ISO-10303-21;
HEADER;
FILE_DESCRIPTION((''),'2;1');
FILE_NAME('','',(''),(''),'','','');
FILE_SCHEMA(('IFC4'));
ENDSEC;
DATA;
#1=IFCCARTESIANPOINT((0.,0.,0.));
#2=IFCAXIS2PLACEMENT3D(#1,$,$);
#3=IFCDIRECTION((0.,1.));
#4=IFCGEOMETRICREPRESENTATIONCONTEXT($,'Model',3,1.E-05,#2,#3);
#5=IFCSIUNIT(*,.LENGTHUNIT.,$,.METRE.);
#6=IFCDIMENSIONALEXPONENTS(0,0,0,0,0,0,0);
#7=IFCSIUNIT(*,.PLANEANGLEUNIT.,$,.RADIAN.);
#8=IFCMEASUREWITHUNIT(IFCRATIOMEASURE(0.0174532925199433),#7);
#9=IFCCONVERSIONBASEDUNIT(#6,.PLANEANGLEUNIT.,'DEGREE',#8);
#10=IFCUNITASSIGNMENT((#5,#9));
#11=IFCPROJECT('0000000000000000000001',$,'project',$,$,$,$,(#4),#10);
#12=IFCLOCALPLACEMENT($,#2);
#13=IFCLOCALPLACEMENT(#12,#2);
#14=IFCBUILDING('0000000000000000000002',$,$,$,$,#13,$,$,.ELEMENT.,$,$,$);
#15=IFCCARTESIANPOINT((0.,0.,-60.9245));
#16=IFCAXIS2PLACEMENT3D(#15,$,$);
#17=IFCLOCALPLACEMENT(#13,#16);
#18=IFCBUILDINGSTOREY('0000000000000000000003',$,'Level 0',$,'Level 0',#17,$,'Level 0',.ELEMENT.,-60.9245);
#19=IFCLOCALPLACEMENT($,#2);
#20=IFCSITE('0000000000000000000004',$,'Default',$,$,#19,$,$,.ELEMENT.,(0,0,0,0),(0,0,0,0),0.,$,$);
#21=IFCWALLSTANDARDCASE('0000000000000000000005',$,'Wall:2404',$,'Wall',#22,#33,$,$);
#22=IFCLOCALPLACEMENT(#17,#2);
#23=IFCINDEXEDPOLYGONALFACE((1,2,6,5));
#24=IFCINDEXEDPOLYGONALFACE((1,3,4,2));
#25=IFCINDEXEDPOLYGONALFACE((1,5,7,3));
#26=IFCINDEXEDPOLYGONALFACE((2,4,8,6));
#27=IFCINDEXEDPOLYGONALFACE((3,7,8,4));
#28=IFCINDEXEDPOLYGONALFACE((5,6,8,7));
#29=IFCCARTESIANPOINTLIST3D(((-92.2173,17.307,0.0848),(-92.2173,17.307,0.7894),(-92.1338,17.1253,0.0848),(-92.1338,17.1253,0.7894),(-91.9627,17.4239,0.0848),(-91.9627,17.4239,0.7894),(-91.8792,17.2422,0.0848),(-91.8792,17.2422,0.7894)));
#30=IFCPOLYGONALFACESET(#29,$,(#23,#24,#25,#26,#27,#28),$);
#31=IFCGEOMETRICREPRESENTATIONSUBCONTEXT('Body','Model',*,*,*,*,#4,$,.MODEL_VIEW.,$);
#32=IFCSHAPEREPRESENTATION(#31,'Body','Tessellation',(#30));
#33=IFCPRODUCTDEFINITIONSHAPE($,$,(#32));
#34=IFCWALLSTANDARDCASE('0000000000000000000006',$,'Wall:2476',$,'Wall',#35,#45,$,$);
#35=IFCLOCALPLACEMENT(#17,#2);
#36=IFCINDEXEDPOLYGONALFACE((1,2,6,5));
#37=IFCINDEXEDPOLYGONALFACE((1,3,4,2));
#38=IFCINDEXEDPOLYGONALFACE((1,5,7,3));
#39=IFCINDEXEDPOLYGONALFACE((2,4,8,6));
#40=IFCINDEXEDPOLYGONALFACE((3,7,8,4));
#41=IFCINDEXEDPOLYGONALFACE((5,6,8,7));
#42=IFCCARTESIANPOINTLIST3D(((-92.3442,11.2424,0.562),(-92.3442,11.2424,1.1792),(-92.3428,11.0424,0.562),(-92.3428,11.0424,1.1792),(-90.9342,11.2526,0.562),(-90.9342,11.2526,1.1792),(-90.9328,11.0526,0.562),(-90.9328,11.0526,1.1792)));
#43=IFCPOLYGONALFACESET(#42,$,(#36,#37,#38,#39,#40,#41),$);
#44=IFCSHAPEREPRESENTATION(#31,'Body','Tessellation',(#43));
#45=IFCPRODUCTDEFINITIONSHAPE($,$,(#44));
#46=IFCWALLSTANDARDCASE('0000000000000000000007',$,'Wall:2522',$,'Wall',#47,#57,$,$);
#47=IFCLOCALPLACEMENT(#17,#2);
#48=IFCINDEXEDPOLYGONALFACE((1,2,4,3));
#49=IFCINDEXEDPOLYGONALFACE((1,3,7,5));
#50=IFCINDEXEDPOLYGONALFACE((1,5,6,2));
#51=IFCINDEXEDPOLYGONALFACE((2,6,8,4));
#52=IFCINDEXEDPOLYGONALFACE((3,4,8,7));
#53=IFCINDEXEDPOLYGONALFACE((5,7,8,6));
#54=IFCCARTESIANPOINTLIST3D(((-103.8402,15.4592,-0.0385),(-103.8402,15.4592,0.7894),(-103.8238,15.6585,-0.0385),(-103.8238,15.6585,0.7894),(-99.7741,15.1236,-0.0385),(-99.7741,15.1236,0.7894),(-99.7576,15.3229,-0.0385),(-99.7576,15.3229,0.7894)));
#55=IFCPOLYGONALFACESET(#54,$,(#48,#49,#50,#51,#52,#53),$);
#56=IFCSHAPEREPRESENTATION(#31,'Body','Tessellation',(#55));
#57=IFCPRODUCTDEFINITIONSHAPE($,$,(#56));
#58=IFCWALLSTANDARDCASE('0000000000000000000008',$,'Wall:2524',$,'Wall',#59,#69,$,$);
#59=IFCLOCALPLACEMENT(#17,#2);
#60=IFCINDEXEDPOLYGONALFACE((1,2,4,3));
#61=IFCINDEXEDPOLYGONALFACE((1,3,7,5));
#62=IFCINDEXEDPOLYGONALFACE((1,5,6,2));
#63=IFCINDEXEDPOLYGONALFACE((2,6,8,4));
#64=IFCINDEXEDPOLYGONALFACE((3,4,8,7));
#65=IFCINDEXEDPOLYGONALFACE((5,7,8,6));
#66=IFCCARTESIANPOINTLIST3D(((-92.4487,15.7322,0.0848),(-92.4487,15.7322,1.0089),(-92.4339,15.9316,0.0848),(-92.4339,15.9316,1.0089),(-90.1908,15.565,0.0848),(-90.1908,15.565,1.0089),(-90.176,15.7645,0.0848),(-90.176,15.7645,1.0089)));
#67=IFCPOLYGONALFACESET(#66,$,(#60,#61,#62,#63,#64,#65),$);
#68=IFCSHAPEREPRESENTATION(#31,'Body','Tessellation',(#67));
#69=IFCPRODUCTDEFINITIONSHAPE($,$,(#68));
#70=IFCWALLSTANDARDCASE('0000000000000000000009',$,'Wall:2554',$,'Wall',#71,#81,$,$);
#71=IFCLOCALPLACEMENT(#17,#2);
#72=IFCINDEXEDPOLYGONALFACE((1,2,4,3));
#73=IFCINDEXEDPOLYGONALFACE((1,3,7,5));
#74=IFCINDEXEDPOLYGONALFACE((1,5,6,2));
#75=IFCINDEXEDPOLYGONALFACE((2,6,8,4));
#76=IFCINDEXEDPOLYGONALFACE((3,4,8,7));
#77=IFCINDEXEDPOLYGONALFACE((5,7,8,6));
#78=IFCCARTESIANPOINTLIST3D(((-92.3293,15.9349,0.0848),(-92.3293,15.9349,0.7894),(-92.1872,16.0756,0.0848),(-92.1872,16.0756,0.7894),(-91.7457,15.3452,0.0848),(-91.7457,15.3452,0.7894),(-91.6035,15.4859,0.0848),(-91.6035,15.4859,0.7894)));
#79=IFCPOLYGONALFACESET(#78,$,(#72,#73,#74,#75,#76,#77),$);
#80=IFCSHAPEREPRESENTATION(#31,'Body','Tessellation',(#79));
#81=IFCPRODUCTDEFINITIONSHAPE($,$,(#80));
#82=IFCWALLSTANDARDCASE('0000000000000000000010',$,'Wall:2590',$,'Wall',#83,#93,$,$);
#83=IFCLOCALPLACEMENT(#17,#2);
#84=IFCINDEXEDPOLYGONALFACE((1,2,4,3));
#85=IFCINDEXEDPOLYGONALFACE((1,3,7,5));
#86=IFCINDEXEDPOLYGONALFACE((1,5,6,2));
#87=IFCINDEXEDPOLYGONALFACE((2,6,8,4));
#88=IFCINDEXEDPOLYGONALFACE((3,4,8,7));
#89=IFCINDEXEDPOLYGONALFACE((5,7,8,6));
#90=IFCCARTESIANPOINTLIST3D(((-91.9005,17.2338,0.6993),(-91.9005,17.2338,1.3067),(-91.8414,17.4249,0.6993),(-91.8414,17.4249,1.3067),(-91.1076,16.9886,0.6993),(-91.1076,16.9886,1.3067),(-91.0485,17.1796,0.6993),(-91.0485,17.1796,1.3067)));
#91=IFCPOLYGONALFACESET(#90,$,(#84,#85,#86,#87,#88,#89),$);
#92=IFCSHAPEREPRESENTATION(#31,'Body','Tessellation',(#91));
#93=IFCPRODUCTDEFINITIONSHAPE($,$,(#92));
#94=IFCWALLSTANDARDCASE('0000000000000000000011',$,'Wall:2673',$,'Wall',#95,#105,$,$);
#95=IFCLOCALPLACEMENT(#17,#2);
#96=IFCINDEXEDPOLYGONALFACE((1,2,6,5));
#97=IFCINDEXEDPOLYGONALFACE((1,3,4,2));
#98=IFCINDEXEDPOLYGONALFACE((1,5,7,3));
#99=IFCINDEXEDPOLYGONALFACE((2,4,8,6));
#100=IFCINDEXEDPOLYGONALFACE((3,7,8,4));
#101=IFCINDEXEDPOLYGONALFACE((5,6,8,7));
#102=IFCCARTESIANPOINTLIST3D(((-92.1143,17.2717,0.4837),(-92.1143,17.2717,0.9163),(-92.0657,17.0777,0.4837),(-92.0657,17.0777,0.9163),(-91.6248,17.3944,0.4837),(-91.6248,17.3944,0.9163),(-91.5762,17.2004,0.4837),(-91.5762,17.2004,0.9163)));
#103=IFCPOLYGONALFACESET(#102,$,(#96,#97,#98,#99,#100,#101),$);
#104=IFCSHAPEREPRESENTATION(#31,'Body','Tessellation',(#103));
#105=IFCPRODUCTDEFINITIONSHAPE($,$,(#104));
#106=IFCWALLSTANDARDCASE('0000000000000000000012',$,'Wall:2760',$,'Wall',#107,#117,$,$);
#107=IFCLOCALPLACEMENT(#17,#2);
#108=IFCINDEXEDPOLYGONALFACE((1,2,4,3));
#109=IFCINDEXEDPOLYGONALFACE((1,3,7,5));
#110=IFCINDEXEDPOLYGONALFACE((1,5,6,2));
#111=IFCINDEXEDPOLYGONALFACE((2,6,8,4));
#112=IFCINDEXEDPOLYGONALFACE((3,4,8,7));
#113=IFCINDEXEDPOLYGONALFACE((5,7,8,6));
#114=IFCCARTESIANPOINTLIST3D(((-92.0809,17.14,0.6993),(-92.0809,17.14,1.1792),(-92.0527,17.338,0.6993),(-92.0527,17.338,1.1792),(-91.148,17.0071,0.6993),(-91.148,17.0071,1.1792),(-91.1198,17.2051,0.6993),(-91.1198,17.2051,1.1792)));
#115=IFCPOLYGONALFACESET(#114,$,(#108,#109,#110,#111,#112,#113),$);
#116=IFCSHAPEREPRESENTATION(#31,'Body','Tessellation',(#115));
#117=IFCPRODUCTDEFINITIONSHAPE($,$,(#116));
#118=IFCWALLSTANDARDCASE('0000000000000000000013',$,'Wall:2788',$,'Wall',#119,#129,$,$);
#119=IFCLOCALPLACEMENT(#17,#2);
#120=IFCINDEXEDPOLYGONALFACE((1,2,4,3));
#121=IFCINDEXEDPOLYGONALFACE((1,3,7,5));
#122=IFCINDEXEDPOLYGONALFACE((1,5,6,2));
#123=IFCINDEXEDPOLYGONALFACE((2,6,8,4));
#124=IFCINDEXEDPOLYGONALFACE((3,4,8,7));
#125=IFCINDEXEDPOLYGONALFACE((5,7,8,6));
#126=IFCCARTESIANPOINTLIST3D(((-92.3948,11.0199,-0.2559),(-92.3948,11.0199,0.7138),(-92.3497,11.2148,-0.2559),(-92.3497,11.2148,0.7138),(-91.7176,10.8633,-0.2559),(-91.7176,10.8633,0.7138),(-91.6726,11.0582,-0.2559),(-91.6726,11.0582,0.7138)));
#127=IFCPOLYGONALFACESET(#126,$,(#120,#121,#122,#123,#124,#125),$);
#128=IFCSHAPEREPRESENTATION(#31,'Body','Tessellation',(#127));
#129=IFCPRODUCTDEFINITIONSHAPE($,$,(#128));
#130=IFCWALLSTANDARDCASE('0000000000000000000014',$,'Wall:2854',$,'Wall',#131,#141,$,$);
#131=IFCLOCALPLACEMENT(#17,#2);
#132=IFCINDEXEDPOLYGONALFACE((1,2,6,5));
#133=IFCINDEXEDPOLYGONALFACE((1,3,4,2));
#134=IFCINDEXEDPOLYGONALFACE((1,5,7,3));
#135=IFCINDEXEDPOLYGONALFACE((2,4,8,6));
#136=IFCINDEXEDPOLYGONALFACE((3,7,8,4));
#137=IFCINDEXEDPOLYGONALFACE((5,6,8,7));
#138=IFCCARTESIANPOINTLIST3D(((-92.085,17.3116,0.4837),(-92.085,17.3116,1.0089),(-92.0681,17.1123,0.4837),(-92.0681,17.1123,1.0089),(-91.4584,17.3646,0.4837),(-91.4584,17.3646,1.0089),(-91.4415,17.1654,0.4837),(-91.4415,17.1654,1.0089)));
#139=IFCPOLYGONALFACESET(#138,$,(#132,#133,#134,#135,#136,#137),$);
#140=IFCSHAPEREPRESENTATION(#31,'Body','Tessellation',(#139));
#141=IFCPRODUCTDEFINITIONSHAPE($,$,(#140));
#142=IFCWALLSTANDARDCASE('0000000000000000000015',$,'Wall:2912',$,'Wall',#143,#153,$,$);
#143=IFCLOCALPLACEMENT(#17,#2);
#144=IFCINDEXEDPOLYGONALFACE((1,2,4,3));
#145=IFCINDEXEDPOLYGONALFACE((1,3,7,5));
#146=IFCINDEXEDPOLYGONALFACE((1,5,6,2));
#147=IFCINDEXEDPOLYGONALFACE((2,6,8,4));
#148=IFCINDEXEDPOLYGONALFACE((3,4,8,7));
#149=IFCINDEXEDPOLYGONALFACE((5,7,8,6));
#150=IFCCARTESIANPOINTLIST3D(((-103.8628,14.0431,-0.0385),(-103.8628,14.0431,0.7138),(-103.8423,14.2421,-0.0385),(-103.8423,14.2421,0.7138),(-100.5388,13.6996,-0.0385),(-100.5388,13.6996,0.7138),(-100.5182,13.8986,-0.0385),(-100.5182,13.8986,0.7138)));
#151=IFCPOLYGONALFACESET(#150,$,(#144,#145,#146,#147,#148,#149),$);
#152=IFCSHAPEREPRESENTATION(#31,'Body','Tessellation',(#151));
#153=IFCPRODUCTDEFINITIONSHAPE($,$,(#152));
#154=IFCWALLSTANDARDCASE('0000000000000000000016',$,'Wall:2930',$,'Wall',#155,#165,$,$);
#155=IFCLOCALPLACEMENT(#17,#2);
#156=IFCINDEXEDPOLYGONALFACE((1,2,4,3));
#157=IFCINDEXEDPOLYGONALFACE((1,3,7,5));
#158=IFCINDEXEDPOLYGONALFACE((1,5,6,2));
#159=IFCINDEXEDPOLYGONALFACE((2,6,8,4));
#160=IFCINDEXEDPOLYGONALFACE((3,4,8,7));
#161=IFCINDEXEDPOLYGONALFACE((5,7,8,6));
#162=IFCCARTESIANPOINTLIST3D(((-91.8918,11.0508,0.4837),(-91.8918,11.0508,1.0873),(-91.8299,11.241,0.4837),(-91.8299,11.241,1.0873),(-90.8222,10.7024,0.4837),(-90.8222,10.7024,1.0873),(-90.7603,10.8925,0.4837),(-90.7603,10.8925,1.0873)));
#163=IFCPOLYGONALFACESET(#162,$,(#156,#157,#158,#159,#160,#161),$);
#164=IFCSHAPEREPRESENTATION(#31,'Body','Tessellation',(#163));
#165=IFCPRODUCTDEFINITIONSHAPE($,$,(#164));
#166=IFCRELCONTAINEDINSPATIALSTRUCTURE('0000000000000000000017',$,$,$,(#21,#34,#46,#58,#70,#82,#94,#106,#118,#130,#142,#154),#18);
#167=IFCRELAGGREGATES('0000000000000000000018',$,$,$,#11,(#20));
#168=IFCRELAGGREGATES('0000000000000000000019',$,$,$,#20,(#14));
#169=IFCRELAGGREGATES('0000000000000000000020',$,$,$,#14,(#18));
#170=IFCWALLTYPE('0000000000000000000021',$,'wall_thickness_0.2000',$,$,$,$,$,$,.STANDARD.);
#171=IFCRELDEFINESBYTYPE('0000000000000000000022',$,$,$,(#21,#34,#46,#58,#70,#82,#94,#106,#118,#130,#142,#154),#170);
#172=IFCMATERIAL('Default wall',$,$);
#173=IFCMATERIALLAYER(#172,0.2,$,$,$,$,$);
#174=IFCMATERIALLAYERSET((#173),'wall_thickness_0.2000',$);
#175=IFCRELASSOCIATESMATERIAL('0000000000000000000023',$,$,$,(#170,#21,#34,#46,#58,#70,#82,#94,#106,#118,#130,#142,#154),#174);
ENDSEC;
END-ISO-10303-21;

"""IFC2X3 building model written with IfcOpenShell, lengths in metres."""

from ifc_helpers import new_model, entity, si_unit, converted_unit, direction, frame, origin, place, context, subcontext, project, spatial, polyline, outline, extrude, material, layer, layer_set, layer_usage, type_object, element, save


model = new_model("IFC2X3")

# Units and contexts
model_context = context("Model", 3, precision=1e-05, world=origin(), true_north=direction((0.0, 1.0)))
body_context = subcontext(model_context, "Body", "Model", "MODEL_VIEW")
ifc_project = project(units=[si_unit("LENGTHUNIT", "METRE"), converted_unit("PLANEANGLEUNIT", "DEGREE", entity("IfcRatioMeasure", 0.0174532925199433), si_unit("PLANEANGLEUNIT", "RADIAN"), dimensions=[0, 0, 0, 0, 0, 0, 0])], contexts=[model_context])

# Site, building, storey
site_placement = place(None, origin())
site = spatial("IfcSite", under=ifc_project, at=site_placement, Name="Default", CompositionType="ELEMENT", RefLatitude=(0, 0, 0, 0), RefLongitude=(0, 0, 0, 0), RefElevation=0.0)
placement_1 = place(None, origin())
building_placement = place(placement_1, origin())
building = spatial("IfcBuilding", under=site, at=building_placement, CompositionType="ELEMENT")
storey_placement = place(building_placement, frame((0.0, 0.0, -60.9245)))
storey = spatial("IfcBuildingStorey", under=building, at=storey_placement, Name="Level 0", ObjectType="Level 0", LongName="Level 0", CompositionType="ELEMENT", Elevation=-60.9245)

# Walls
ifc_material = material(Name="Default wall")
ifc_layer = layer(ifc_material, 0.2)
ifc_layer_set = layer_set([ifc_layer], Name="wall_thickness_0.2000")
ifc_layer_usage = layer_usage(ifc_layer_set, "AXIS2", "POSITIVE", -0.1)
wall_type = type_object("IfcWallType", Name="wall_thickness_0.2000", PredefinedType="STANDARD", material=ifc_layer_set)
placement_2 = place(building_placement, frame((0.0, 0.0, -60.8397)))
wall_1_placement = place(placement_2, frame((-91.921, 17.3331, 0.0), z_axis=(0.0, 0.0, 1.0), x_axis=(-0.908755, -0.41733, 0.0)))
element("IfcWallStandardCase", 1, at=wall_1_placement, inside=storey, type_object=wall_type, material=ifc_layer_usage, Name="Wall:2404", ObjectType="Wall", context=body_context, shape_type="SweptSolid", body=[
    extrude(outline(polyline([(0.2802, -0.1), (0.2802, 0.1), (0.0, 0.1), (0.0, -0.1), (0.2802, -0.1)])), origin(), (0.0, 0.0, 1.0), 0.7047),
])
placement_3 = place(building_placement, frame((0.0, 0.0, -60.3625)))
wall_2_placement = place(placement_3, frame((-92.3435, 11.1424, 0.0), z_axis=(0.0, 0.0, 1.0), x_axis=(0.999974, 0.007215, 0.0)))
element("IfcWallStandardCase", 2, at=wall_2_placement, inside=storey, type_object=wall_type, material=ifc_layer_usage, Name="Wall:2476", ObjectType="Wall", context=body_context, shape_type="SweptSolid", body=[
    extrude(outline(polyline([(1.41, -0.1), (1.41, 0.1), (0.0, 0.1), (0.0, -0.1), (1.41, -0.1)])), origin(), (0.0, 0.0, 1.0), 0.6172),
])
placement_4 = place(building_placement, frame((0.0, 0.0, -60.963)))
wall_3_placement = place(placement_4, frame((-103.832, 15.5588, 0.0), z_axis=(0.0, 0.0, 1.0), x_axis=(0.996611, -0.082256, 0.0)))
element("IfcWallStandardCase", 3, at=wall_3_placement, inside=storey, type_object=wall_type, material=ifc_layer_usage, Name="Wall:2522", ObjectType="Wall", context=body_context, shape_type="SweptSolid", body=[
    extrude(outline(polyline([(4.08, -0.1), (4.08, 0.1), (0.0, 0.1), (0.0, -0.1), (4.08, -0.1)])), origin(), (0.0, 0.0, 1.0), 0.828),
])
placement_5 = place(building_placement, frame((0.0, 0.0, -60.8397)))
wall_4_placement = place(placement_5, frame((-92.4413, 15.8319, 0.0), z_axis=(0.0, 0.0, 1.0), x_axis=(0.997271, -0.073825, 0.0)))
element("IfcWallStandardCase", 4, at=wall_4_placement, inside=storey, type_object=wall_type, material=ifc_layer_usage, Name="Wall:2524", ObjectType="Wall", context=body_context, shape_type="SweptSolid", body=[
    extrude(outline(polyline([(2.2641, -0.1), (2.2641, 0.1), (0.0, 0.1), (0.0, -0.1), (2.2641, -0.1)])), origin(), (0.0, 0.0, 1.0), 0.9242),
])
placement_6 = place(building_placement, frame((0.0, 0.0, -60.8397)))
wall_5_placement = place(placement_6, frame((-91.6746, 15.4156, 0.0), z_axis=(0.0, 0.0, 1.0), x_axis=(-0.703451, 0.710744, 0.0)))
element("IfcWallStandardCase", 5, at=wall_5_placement, inside=storey, type_object=wall_type, material=ifc_layer_usage, Name="Wall:2554", ObjectType="Wall", context=body_context, shape_type="SweptSolid", body=[
    extrude(outline(polyline([(0.8297, -0.1), (0.8297, 0.1), (0.0, 0.1), (0.0, -0.1), (0.8297, -0.1)])), origin(), (0.0, 0.0, 1.0), 0.7047),
])
placement_7 = place(building_placement, frame((0.0, 0.0, -60.2252)))
wall_6_placement = place(placement_7, frame((-91.8709, 17.3294, 0.0), z_axis=(0.0, 0.0, 1.0), x_axis=(0.955335, -0.295525, 0.0)))
element("IfcWallStandardCase", 6, at=wall_6_placement, inside=storey, type_object=wall_type, material=ifc_layer_usage, Name="Wall:2590", ObjectType="Wall", context=body_context, shape_type="SweptSolid", body=[
    extrude(outline(polyline([(0.83, -0.1), (0.83, 0.1), (0.0, 0.1), (0.0, -0.1), (0.83, -0.1)])), origin(), (0.0, 0.0, 1.0), 0.6075),
])
placement_8 = place(building_placement, frame((0.0, 0.0, -60.4408)))
wall_7_placement = place(placement_8, frame((-92.09, 17.1747, 0.0), z_axis=(0.0, 0.0, 1.0), x_axis=(0.969996, 0.243119, 0.0)))
element("IfcWallStandardCase", 7, at=wall_7_placement, inside=storey, type_object=wall_type, material=ifc_layer_usage, Name="Wall:2673", ObjectType="Wall", context=body_context, shape_type="SweptSolid", body=[
    extrude(outline(polyline([(0.5047, -0.1), (0.5047, 0.1), (0.0, 0.1), (0.0, -0.1), (0.5047, -0.1)])), origin(), (0.0, 0.0, 1.0), 0.4326),
])
placement_9 = place(building_placement, frame((0.0, 0.0, -60.2252)))
wall_8_placement = place(placement_9, frame((-92.0668, 17.239, 0.0), z_axis=(0.0, 0.0, 1.0), x_axis=(0.99, -0.141065, 0.0)))
element("IfcWallStandardCase", 8, at=wall_8_placement, inside=storey, type_object=wall_type, material=ifc_layer_usage, Name="Wall:2760", ObjectType="Wall", context=body_context, shape_type="SweptSolid", body=[
    extrude(outline(polyline([(0.9423, -0.1), (0.9423, 0.1), (0.0, 0.1), (0.0, -0.1), (0.9423, -0.1)])), origin(), (0.0, 0.0, 1.0), 0.4799),
])
placement_10 = place(building_placement, frame((0.0, 0.0, -61.1804)))
wall_9_placement = place(placement_10, frame((-92.3722, 11.1174, 0.0), z_axis=(0.0, 0.0, 1.0), x_axis=(0.97429, -0.225298, 0.0)))
element("IfcWallStandardCase", 9, at=wall_9_placement, inside=storey, type_object=wall_type, material=ifc_layer_usage, Name="Wall:2788", ObjectType="Wall", context=body_context, shape_type="SweptSolid", body=[
    extrude(outline(polyline([(0.695, -0.1), (0.695, 0.1), (0.0, 0.1), (0.0, -0.1), (0.695, -0.1)])), origin(), (0.0, 0.0, 1.0), 0.9697),
])
placement_11 = place(building_placement, frame((0.0, 0.0, -60.4408)))
wall_10_placement = place(placement_11, frame((-92.0765, 17.212, 0.0), z_axis=(0.0, 0.0, 1.0), x_axis=(0.996438, 0.084324, 0.0)))
element("IfcWallStandardCase", 10, at=wall_10_placement, inside=storey, type_object=wall_type, material=ifc_layer_usage, Name="Wall:2854", ObjectType="Wall", context=body_context, shape_type="SweptSolid", body=[
    extrude(outline(polyline([(0.6288, -0.1), (0.6288, 0.1), (0.0, 0.1), (0.0, -0.1), (0.6288, -0.1)])), origin(), (0.0, 0.0, 1.0), 0.5252),
])
placement_12 = place(building_placement, frame((0.0, 0.0, -60.963)))
wall_11_placement = place(placement_12, frame((-103.8525, 14.1426, 0.0), z_axis=(0.0, 0.0, 1.0), x_axis=(0.994703, -0.102791, 0.0)))
element("IfcWallStandardCase", 11, at=wall_11_placement, inside=storey, type_object=wall_type, material=ifc_layer_usage, Name="Wall:2912", ObjectType="Wall", context=body_context, shape_type="SweptSolid", body=[
    extrude(outline(polyline([(3.3417, -0.1), (3.3417, 0.1), (0.0, 0.1), (0.0, -0.1), (3.3417, -0.1)])), origin(), (0.0, 0.0, 1.0), 0.7523),
])
placement_13 = place(building_placement, frame((0.0, 0.0, -60.4408)))
wall_12_placement = place(placement_13, frame((-91.8609, 11.1459, 0.0), z_axis=(0.0, 0.0, 1.0), x_axis=(0.950828, -0.309719, 0.0)))
element("IfcWallStandardCase", 12, at=wall_12_placement, inside=storey, type_object=wall_type, material=ifc_layer_usage, Name="Wall:2930", ObjectType="Wall", context=body_context, shape_type="SweptSolid", body=[
    extrude(outline(polyline([(1.1249, -0.1), (1.1249, 0.1), (0.0, 0.1), (0.0, -0.1), (1.1249, -0.1)])), origin(), (0.0, 0.0, 1.0), 0.6036),
])

save(model, "model.ifc")
